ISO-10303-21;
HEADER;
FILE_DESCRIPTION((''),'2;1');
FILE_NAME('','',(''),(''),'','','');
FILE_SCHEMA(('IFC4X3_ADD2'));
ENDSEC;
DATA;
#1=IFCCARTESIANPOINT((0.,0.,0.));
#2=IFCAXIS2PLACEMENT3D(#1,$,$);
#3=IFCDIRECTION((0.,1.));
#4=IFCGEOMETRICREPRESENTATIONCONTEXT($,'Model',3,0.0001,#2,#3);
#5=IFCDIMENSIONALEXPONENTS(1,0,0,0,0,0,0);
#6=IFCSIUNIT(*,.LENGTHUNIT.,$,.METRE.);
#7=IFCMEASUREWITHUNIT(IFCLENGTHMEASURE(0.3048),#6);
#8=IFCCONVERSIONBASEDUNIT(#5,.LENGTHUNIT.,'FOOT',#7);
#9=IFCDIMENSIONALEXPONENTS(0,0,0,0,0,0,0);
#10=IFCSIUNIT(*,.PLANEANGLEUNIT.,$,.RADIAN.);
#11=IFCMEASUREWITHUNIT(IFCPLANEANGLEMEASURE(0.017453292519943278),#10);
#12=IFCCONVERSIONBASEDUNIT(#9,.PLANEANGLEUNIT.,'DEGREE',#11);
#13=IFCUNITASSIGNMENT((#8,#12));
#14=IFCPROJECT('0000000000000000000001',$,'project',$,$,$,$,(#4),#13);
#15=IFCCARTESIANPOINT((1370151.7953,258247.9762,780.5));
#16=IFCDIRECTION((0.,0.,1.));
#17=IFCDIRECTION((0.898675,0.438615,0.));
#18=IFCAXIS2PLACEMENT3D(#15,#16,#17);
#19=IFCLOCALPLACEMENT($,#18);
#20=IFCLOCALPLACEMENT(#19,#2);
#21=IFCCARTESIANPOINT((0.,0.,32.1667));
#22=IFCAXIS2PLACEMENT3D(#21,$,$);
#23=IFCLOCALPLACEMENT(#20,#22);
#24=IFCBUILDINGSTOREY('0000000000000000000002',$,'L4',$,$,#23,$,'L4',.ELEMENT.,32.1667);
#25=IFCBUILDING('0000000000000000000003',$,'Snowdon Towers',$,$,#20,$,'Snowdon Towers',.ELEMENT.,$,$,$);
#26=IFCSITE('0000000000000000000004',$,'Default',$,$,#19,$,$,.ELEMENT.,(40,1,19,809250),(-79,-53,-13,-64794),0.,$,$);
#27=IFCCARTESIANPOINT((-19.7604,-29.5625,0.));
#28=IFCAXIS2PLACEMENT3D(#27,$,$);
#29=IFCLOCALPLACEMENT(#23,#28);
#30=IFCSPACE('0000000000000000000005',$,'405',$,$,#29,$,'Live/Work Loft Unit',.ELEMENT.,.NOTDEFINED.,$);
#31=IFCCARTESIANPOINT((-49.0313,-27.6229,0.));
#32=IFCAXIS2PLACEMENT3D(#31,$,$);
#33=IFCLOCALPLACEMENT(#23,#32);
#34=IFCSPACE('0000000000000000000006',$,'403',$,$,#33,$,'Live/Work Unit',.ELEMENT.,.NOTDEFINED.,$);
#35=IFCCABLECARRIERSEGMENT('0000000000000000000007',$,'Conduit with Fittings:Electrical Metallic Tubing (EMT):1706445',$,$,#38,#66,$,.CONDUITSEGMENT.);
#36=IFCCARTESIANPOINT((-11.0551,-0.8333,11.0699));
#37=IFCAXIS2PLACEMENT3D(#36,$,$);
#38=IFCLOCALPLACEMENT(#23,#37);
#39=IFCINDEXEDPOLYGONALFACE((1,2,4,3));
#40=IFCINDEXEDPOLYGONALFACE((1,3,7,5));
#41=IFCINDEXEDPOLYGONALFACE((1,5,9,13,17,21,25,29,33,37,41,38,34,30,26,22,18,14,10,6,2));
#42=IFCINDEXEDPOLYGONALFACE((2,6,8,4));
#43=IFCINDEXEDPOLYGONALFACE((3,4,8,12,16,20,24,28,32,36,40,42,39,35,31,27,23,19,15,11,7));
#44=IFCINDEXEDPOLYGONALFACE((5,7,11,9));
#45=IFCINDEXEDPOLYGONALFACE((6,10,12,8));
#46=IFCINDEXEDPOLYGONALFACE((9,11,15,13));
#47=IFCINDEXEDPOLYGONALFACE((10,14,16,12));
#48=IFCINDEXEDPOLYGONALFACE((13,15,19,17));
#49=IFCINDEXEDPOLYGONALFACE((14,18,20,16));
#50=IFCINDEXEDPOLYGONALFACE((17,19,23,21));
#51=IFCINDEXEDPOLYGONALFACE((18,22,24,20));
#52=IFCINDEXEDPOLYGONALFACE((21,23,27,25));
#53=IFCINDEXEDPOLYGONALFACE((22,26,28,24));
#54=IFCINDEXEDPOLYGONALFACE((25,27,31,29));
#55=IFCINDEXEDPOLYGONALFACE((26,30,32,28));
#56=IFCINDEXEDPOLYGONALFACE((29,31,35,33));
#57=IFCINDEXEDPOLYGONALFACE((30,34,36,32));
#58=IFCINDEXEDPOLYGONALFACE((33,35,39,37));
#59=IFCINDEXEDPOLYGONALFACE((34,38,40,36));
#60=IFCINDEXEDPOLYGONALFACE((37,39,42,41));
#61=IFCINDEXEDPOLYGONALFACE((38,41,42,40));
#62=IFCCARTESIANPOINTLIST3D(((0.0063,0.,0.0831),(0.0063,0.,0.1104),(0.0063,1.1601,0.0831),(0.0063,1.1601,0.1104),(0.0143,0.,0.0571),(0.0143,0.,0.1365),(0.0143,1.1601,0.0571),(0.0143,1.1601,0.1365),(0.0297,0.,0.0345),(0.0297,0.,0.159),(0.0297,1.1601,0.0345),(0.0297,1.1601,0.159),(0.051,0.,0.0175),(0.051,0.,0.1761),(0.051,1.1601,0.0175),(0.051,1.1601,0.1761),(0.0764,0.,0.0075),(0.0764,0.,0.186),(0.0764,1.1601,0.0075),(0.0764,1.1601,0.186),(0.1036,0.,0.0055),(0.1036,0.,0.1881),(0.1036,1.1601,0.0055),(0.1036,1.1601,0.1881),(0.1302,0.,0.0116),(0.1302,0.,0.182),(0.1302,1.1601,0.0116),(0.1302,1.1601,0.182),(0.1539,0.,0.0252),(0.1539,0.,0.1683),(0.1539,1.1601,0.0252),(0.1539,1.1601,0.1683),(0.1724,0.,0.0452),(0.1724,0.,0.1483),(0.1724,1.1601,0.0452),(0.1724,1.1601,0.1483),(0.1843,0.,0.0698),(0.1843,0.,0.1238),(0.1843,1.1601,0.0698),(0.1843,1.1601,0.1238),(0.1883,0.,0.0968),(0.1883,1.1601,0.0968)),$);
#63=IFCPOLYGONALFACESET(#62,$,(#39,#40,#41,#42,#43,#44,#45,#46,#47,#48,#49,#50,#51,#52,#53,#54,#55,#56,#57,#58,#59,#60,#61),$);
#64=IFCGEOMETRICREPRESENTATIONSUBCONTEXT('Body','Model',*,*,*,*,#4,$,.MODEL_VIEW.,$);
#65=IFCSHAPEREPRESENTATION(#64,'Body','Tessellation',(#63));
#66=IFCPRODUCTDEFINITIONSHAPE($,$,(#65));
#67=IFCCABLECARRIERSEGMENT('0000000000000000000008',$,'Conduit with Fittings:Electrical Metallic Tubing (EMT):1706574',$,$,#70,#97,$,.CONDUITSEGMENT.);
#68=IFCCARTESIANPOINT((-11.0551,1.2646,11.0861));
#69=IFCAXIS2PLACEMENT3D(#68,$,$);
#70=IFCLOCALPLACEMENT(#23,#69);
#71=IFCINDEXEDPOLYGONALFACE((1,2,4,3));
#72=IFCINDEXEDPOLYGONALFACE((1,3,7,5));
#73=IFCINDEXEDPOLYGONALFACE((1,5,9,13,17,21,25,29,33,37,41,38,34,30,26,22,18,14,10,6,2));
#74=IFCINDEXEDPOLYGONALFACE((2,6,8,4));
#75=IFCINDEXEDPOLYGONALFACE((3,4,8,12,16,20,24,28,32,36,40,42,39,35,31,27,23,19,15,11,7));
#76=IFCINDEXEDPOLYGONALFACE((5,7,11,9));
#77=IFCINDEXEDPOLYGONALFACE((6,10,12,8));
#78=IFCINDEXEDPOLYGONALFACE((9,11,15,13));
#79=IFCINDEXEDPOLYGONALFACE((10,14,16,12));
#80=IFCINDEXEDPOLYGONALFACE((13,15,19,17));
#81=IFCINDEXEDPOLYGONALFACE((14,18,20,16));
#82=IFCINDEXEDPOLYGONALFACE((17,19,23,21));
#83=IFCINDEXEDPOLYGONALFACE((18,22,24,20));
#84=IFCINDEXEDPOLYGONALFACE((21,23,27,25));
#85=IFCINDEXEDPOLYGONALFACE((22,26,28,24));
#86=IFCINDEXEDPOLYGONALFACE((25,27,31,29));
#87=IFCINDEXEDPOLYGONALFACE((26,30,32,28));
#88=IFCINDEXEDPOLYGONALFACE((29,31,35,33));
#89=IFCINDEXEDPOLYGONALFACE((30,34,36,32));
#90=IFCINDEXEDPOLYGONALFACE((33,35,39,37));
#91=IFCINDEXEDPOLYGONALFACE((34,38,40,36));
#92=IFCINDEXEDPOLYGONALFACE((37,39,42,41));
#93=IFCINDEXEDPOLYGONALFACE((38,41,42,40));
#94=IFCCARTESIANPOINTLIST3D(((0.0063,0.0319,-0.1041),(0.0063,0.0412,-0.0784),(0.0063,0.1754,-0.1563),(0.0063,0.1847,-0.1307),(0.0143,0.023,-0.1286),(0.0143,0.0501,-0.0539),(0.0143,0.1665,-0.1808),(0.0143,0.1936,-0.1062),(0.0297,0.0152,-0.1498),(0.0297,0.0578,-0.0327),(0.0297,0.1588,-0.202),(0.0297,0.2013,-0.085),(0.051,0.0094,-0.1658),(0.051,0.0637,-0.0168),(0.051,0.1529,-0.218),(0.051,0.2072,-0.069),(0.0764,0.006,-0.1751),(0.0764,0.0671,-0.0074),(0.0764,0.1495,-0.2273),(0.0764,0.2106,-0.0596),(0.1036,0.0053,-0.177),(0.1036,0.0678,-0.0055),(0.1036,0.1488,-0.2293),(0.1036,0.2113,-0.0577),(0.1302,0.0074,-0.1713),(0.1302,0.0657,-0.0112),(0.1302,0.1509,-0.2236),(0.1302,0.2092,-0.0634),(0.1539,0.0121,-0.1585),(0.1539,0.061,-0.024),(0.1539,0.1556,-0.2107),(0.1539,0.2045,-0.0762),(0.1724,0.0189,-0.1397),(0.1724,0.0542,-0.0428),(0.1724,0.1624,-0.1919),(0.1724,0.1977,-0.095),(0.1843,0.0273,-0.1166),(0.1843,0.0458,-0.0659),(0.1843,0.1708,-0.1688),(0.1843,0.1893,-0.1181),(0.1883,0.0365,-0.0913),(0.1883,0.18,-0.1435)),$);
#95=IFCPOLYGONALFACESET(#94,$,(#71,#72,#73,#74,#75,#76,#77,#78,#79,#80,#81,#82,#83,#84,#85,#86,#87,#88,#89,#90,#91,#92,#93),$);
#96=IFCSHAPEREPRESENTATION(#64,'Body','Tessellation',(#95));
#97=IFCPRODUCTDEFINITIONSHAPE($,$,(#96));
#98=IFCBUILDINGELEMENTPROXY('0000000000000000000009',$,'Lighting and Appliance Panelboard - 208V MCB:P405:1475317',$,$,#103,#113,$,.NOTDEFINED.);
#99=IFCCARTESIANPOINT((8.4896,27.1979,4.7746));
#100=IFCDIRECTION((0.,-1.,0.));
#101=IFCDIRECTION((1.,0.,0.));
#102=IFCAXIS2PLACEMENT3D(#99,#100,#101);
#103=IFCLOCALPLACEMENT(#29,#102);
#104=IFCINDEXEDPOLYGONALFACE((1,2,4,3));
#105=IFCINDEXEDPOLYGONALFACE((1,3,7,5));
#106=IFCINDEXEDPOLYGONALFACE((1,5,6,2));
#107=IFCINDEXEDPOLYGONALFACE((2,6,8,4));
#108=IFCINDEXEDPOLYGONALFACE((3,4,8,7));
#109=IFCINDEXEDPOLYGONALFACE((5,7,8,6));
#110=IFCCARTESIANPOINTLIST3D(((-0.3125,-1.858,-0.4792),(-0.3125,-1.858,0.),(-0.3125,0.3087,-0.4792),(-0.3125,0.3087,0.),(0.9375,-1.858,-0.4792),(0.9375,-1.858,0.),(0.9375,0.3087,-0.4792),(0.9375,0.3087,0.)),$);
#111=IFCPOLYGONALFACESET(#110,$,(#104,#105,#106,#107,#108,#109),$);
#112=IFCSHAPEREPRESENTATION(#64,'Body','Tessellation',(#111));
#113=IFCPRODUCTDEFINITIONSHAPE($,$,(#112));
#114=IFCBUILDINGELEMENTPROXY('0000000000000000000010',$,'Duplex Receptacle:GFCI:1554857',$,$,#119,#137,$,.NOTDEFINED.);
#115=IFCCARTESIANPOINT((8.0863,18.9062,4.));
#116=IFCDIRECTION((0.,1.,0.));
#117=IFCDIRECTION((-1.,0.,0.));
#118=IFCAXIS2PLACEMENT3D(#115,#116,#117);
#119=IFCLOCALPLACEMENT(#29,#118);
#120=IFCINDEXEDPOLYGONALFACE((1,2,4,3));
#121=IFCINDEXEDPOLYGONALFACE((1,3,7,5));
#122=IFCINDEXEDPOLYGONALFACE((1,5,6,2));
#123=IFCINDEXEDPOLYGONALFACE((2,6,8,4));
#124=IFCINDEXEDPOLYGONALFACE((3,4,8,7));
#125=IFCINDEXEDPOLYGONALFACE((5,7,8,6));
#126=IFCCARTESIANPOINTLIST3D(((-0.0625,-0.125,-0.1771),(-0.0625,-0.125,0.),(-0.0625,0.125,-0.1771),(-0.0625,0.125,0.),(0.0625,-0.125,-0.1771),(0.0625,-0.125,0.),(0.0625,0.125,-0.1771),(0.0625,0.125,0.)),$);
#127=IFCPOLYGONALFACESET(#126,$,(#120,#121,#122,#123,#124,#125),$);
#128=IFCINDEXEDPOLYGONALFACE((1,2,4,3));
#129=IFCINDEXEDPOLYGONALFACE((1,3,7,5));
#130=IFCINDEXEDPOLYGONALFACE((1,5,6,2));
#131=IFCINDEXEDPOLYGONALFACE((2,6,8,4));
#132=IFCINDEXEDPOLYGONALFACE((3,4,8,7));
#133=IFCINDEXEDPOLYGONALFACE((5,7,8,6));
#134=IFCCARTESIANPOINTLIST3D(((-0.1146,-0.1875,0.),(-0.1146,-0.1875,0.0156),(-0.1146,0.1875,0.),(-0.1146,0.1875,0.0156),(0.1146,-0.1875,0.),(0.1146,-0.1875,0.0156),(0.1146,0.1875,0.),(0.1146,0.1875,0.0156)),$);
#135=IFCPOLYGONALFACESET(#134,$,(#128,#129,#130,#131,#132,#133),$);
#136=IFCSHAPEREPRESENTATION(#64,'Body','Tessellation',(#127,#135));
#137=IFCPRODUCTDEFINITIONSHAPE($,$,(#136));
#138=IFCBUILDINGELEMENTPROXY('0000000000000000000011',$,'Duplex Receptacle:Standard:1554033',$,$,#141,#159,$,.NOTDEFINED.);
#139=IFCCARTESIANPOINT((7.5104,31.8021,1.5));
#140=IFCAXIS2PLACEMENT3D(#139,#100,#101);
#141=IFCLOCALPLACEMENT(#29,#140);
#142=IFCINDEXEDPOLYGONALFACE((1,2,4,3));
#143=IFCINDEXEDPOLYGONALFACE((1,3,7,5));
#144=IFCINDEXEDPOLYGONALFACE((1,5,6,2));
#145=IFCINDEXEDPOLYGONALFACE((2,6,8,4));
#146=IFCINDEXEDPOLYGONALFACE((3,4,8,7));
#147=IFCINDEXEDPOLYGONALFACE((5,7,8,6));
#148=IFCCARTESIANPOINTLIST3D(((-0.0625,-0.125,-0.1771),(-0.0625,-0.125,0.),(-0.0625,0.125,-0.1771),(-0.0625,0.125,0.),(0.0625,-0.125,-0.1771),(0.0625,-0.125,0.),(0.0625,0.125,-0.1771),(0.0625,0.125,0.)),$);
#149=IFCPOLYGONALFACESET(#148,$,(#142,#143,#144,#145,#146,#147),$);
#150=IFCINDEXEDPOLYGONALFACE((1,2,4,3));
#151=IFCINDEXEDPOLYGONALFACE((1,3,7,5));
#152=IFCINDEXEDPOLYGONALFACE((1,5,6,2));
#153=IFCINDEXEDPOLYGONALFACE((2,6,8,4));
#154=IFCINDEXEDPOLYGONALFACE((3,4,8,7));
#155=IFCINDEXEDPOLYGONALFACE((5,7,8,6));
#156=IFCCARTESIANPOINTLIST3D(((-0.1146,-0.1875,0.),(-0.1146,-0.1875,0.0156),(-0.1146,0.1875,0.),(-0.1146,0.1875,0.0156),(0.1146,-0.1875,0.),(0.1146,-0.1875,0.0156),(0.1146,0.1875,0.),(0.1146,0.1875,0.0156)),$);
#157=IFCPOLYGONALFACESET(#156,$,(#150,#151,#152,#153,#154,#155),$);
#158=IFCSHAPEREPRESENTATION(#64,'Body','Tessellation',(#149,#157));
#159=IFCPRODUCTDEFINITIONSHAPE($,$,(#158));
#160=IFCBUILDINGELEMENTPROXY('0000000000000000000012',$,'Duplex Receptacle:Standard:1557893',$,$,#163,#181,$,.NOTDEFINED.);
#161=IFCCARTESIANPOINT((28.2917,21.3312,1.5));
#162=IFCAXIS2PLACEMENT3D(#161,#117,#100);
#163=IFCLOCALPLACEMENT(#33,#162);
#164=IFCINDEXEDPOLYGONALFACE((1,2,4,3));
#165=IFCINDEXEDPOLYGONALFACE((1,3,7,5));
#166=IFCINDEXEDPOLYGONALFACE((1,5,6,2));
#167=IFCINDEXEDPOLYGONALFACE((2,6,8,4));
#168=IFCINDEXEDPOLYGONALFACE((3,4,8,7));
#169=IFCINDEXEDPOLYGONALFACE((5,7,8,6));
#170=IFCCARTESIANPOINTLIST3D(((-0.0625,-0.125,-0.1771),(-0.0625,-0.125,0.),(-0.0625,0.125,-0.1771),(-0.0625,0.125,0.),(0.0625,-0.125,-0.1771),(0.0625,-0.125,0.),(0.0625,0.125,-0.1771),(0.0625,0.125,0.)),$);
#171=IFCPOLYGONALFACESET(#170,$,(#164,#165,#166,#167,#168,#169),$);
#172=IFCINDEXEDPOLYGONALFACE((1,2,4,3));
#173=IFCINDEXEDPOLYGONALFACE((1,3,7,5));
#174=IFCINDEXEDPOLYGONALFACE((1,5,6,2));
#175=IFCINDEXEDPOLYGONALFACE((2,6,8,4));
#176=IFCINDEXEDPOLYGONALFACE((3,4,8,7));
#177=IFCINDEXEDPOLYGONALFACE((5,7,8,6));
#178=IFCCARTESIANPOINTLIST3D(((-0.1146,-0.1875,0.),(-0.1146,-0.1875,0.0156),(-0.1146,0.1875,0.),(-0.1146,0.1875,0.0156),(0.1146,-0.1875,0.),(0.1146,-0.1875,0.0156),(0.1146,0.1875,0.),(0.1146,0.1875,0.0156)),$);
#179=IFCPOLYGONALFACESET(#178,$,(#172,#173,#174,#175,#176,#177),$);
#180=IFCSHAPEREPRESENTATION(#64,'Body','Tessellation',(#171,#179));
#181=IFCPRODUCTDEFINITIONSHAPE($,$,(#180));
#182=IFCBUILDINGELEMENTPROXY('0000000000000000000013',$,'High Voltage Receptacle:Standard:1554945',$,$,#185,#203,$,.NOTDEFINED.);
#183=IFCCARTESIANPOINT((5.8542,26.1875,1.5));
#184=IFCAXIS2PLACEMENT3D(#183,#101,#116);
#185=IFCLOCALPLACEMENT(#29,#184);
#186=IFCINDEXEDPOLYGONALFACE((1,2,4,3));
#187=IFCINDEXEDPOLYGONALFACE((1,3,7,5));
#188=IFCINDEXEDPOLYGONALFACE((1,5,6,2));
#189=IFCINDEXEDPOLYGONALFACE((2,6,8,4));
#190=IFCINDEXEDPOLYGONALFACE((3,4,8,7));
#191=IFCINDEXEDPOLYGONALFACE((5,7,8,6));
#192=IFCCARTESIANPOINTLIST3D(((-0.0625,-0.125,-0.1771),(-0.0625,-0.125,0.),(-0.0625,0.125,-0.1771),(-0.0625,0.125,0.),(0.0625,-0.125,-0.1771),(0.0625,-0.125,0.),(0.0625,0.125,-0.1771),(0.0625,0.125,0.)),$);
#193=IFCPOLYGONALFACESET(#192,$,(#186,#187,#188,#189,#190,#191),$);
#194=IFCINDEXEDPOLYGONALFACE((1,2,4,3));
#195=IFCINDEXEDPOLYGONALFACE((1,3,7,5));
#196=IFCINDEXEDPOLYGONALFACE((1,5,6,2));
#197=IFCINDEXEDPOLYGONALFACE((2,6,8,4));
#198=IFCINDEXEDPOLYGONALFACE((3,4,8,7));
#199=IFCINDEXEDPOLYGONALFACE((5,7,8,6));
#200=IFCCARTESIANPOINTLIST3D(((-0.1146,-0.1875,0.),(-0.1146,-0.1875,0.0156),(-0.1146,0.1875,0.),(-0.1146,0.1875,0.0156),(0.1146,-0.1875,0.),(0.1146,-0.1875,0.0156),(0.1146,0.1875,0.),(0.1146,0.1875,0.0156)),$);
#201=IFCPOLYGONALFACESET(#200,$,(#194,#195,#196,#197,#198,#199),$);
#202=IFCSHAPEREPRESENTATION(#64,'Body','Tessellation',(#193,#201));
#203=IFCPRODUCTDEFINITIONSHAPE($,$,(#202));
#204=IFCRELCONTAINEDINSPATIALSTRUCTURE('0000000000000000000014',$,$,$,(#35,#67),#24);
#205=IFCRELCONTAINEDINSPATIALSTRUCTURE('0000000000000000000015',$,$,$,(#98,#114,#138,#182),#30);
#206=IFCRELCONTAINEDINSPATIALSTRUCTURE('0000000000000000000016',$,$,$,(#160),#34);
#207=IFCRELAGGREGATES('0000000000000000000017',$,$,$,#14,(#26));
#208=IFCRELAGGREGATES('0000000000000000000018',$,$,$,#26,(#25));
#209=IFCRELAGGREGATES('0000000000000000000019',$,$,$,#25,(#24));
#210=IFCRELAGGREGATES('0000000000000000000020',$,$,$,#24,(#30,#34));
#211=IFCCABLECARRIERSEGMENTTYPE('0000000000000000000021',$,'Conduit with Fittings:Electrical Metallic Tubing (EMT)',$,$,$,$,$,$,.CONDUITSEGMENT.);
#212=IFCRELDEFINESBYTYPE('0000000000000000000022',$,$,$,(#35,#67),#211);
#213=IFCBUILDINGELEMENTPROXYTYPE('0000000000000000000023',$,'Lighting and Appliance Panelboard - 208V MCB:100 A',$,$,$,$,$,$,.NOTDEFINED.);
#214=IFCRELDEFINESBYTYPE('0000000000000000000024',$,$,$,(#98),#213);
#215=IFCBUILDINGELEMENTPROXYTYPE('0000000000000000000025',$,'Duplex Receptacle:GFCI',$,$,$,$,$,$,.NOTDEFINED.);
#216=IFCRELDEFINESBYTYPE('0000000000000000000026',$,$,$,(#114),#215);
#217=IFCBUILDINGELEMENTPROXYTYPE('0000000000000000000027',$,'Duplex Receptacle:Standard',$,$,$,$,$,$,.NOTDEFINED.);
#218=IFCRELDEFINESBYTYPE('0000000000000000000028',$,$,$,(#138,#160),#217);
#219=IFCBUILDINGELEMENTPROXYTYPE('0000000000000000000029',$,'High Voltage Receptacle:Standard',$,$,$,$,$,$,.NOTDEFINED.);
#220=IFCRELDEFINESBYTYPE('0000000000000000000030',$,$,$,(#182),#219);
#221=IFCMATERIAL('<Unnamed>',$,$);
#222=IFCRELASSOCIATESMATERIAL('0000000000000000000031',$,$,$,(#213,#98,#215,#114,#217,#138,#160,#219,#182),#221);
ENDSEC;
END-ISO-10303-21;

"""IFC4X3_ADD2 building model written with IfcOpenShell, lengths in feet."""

from ifc_helpers import new_model, entity, si_unit, converted_unit, direction, frame, frame_2d, origin, origin_2d_with_axis, place, context, subcontext, project, spatial, rectangle, circle, extrude, source, transform, mapped, material, type_object, type_shapes, element, save


model = new_model("IFC4X3_ADD2")

# Units and contexts
model_context = context("Model", 3, precision=0.0001, world=origin(), true_north=direction((0.0, 1.0)))
body_context = subcontext(model_context, "Body", "Model", "MODEL_VIEW")
ifc_project = project(units=[converted_unit("LENGTHUNIT", "FOOT", entity("IfcLengthMeasure", 0.3048), si_unit("LENGTHUNIT", "METRE"), dimensions=[1, 0, 0, 0, 0, 0, 0]), converted_unit("PLANEANGLEUNIT", "DEGREE", entity("IfcPlaneAngleMeasure", 0.017453292519943278), si_unit("PLANEANGLEUNIT", "RADIAN"), dimensions=[0, 0, 0, 0, 0, 0, 0])], contexts=[model_context])

# Site, building, storey
site_placement = place(None, frame((1370151.7953, 258247.9762, 780.5), z_axis=(0.0, 0.0, 1.0), x_axis=(0.898675, 0.438615, 0.0)))
site = spatial("IfcSite", under=ifc_project, at=site_placement, Name="Default", CompositionType="ELEMENT", RefLatitude=(40, 1, 19, 809250), RefLongitude=(-79, -53, -13, -64794), RefElevation=0.0)
building_placement = place(site_placement, origin())
building = spatial("IfcBuilding", under=site, at=building_placement, Name="Snowdon Towers", LongName="Snowdon Towers", CompositionType="ELEMENT")
storey_placement = place(building_placement, frame((0.0, 0.0, 32.1667)))
storey = spatial("IfcBuildingStorey", under=building, at=storey_placement, Name="L4", LongName="L4", CompositionType="ELEMENT", Elevation=32.1667)

# Cable carrier segments
cable_carrier_segment_type = type_object("IfcCableCarrierSegmentType", Name="Conduit with Fittings:Electrical Metallic Tubing (EMT)", PredefinedType="CONDUITSEGMENT")
cable_carrier_segment_1_placement = place(storey_placement, frame((-11.0551, -0.8333, 11.0699)))
element("IfcCableCarrierSegment", 1, at=cable_carrier_segment_1_placement, inside=storey, type_object=cable_carrier_segment_type, Name="Conduit with Fittings:Electrical Metallic Tubing (EMT):1706445", PredefinedType="CONDUITSEGMENT", context=body_context, shape_type="SweptSolid", body=[
    extrude(circle(Radius=0.0915, at=origin_2d_with_axis()), frame((0.0968, 0.0, 0.0968), z_axis=(0.0, 1.0, 0.0), x_axis=(1.0, 0.0, 0.0)), (0.0, 0.0, 1.0), 1.1601),
])
cable_carrier_segment_2_placement = place(storey_placement, frame((-11.0551, 1.2646, 11.0861)))
element("IfcCableCarrierSegment", 2, at=cable_carrier_segment_2_placement, inside=storey, type_object=cable_carrier_segment_type, Name="Conduit with Fittings:Electrical Metallic Tubing (EMT):1706574", PredefinedType="CONDUITSEGMENT", context=body_context, shape_type="SweptSolid", body=[
    extrude(circle(Radius=0.0915, at=origin_2d_with_axis()), frame((0.0968, 0.18, -0.1435), z_axis=(0.0, -0.939693, 0.34202), x_axis=(1.0, 0.0, 0.0)), (0.0, 0.0, 1.0), 0.1527),
])

# Shared definitions
space_1_placement = place(storey_placement, frame((-19.7604, -29.5625, 0.0)))
space_1 = spatial("IfcSpace", under=storey, at=space_1_placement, Name="405", LongName="Live/Work Loft Unit", CompositionType="ELEMENT", PredefinedType="NOTDEFINED")

# Building element proxies
ifc_material_1 = material(Name="<Unnamed>")
building_element_proxy_type_1 = type_object("IfcBuildingElementProxyType", Name="Lighting and Appliance Panelboard - 208V MCB:100 A", PredefinedType="NOTDEFINED", material=ifc_material_1)
shared_shape_1 = source(origin(), body_context, "Body", "SweptSolid", [
    extrude(rectangle(XDim=1.25, YDim=2.1667, at=origin_2d_with_axis()), frame((0.3125, -0.7746, -0.4792), z_axis=(0.0, 0.0, 1.0), x_axis=(-1.0, 0.0, 0.0)), (0.0, 0.0, 1.0), 0.4792),
])
type_shapes(building_element_proxy_type_1, [shared_shape_1])
proxy_1_placement = place(space_1_placement, frame((8.4896, 27.1979, 4.7746), z_axis=(0.0, -1.0, 0.0), x_axis=(1.0, 0.0, 0.0)))
element("IfcBuildingElementProxy", 3, at=proxy_1_placement, inside=space_1, type_object=building_element_proxy_type_1, material=ifc_material_1, Name="Lighting and Appliance Panelboard - 208V MCB:P405:1475317", PredefinedType="NOTDEFINED", context=body_context, shape_type="MappedRepresentation", body=[
    mapped(shared_shape_1, transform((0.0, 0.0, 0.0), scale=1.0)),
])
building_element_proxy_type_2 = type_object("IfcBuildingElementProxyType", Name="Duplex Receptacle:GFCI", PredefinedType="NOTDEFINED", material=ifc_material_1)
shared_shape_2 = source(origin(), body_context, "Body", "SweptSolid", [
    extrude(rectangle(XDim=0.125, YDim=0.25, at=origin_2d_with_axis()), frame((0.0, 0.0, -0.1771), z_axis=(0.0, 0.0, 1.0), x_axis=(-1.0, 0.0, 0.0)), (0.0, 0.0, 1.0), 0.1771),
    extrude(rectangle(XDim=0.2292, YDim=0.375, at=frame_2d((0.0, 0.0), x_axis=(1.0, 0.0))), frame((0.0, 0.0, 0.0), z_axis=(0.0, 0.0, 1.0), x_axis=(-1.0, 0.0, 0.0)), (0.0, 0.0, 1.0), 0.0156),
])
type_shapes(building_element_proxy_type_2, [shared_shape_2])
proxy_2_placement = place(space_1_placement, frame((8.0863, 18.9062, 4.0), z_axis=(0.0, 1.0, 0.0), x_axis=(-1.0, 0.0, 0.0)))
element("IfcBuildingElementProxy", 4, at=proxy_2_placement, inside=space_1, type_object=building_element_proxy_type_2, material=ifc_material_1, Name="Duplex Receptacle:GFCI:1554857", PredefinedType="NOTDEFINED", context=body_context, shape_type="MappedRepresentation", body=[
    mapped(shared_shape_2, transform((0.0, 0.0, 0.0), scale=1.0)),
])
building_element_proxy_type_3 = type_object("IfcBuildingElementProxyType", Name="Duplex Receptacle:Standard", PredefinedType="NOTDEFINED", material=ifc_material_1)
shared_shape_3 = source(origin(), body_context, "Body", "SweptSolid", [
    extrude(rectangle(XDim=0.125, YDim=0.25, at=origin_2d_with_axis()), frame((0.0, 0.0, -0.1771), z_axis=(0.0, 0.0, 1.0), x_axis=(-1.0, 0.0, 0.0)), (0.0, 0.0, 1.0), 0.1771),
    extrude(rectangle(XDim=0.2292, YDim=0.375, at=frame_2d((0.0, 0.0), x_axis=(1.0, 0.0))), frame((0.0, 0.0, 0.0), z_axis=(0.0, 0.0, 1.0), x_axis=(-1.0, 0.0, 0.0)), (0.0, 0.0, 1.0), 0.0156),
])
type_shapes(building_element_proxy_type_3, [shared_shape_3])
for number, where, z_axis, x_axis, name in (
    (5, (7.5104, 31.8021, 1.5), (0.0, -1.0, 0.0), (1.0, 0.0, 0.0), "Duplex Receptacle:Standard:1554033"),
):
    element("IfcBuildingElementProxy", number, at=place(space_1_placement, frame(where, z_axis=z_axis, x_axis=x_axis)), inside=space_1, type_object=building_element_proxy_type_3, material=ifc_material_1, Name=name, PredefinedType="NOTDEFINED", context=body_context, shape_type="MappedRepresentation", body=[
        mapped(shared_shape_3, transform((0.0, 0.0, 0.0), scale=1.0)),
    ])

# Shared definitions
space_2_placement = place(storey_placement, frame((-49.0313, -27.6229, 0.0)))
space_2 = spatial("IfcSpace", under=storey, at=space_2_placement, Name="403", LongName="Live/Work Unit", CompositionType="ELEMENT", PredefinedType="NOTDEFINED")

# Building element proxies
proxy_3_placement = place(space_2_placement, frame((28.2917, 21.3312, 1.5), z_axis=(-1.0, 0.0, 0.0), x_axis=(0.0, -1.0, 0.0)))
element("IfcBuildingElementProxy", 6, at=proxy_3_placement, inside=space_2, type_object=building_element_proxy_type_3, material=ifc_material_1, Name="Duplex Receptacle:Standard:1557893", PredefinedType="NOTDEFINED", context=body_context, shape_type="MappedRepresentation", body=[
    mapped(shared_shape_3, transform((0.0, 0.0, 0.0), scale=1.0)),
])
building_element_proxy_type_4 = type_object("IfcBuildingElementProxyType", Name="High Voltage Receptacle:Standard", PredefinedType="NOTDEFINED", material=ifc_material_1)
shared_shape_4 = source(origin(), body_context, "Body", "SweptSolid", [
    extrude(rectangle(XDim=0.125, YDim=0.25, at=origin_2d_with_axis()), frame((0.0, 0.0, -0.1771), z_axis=(0.0, 0.0, 1.0), x_axis=(-1.0, 0.0, 0.0)), (0.0, 0.0, 1.0), 0.1771),
    extrude(rectangle(XDim=0.2292, YDim=0.375, at=frame_2d((0.0, 0.0), x_axis=(1.0, 0.0))), frame((0.0, 0.0, 0.0), z_axis=(0.0, 0.0, 1.0), x_axis=(-1.0, 0.0, 0.0)), (0.0, 0.0, 1.0), 0.0156),
])
type_shapes(building_element_proxy_type_4, [shared_shape_4])
proxy_4_placement = place(space_1_placement, frame((5.8542, 26.1875, 1.5), z_axis=(1.0, 0.0, 0.0), x_axis=(0.0, 1.0, 0.0)))
element("IfcBuildingElementProxy", 7, at=proxy_4_placement, inside=space_1, type_object=building_element_proxy_type_4, material=ifc_material_1, Name="High Voltage Receptacle:Standard:1554945", PredefinedType="NOTDEFINED", context=body_context, shape_type="MappedRepresentation", body=[
    mapped(shared_shape_4, transform((0.0, 0.0, 0.0), scale=1.0)),
])

save(model, "model.ifc")
